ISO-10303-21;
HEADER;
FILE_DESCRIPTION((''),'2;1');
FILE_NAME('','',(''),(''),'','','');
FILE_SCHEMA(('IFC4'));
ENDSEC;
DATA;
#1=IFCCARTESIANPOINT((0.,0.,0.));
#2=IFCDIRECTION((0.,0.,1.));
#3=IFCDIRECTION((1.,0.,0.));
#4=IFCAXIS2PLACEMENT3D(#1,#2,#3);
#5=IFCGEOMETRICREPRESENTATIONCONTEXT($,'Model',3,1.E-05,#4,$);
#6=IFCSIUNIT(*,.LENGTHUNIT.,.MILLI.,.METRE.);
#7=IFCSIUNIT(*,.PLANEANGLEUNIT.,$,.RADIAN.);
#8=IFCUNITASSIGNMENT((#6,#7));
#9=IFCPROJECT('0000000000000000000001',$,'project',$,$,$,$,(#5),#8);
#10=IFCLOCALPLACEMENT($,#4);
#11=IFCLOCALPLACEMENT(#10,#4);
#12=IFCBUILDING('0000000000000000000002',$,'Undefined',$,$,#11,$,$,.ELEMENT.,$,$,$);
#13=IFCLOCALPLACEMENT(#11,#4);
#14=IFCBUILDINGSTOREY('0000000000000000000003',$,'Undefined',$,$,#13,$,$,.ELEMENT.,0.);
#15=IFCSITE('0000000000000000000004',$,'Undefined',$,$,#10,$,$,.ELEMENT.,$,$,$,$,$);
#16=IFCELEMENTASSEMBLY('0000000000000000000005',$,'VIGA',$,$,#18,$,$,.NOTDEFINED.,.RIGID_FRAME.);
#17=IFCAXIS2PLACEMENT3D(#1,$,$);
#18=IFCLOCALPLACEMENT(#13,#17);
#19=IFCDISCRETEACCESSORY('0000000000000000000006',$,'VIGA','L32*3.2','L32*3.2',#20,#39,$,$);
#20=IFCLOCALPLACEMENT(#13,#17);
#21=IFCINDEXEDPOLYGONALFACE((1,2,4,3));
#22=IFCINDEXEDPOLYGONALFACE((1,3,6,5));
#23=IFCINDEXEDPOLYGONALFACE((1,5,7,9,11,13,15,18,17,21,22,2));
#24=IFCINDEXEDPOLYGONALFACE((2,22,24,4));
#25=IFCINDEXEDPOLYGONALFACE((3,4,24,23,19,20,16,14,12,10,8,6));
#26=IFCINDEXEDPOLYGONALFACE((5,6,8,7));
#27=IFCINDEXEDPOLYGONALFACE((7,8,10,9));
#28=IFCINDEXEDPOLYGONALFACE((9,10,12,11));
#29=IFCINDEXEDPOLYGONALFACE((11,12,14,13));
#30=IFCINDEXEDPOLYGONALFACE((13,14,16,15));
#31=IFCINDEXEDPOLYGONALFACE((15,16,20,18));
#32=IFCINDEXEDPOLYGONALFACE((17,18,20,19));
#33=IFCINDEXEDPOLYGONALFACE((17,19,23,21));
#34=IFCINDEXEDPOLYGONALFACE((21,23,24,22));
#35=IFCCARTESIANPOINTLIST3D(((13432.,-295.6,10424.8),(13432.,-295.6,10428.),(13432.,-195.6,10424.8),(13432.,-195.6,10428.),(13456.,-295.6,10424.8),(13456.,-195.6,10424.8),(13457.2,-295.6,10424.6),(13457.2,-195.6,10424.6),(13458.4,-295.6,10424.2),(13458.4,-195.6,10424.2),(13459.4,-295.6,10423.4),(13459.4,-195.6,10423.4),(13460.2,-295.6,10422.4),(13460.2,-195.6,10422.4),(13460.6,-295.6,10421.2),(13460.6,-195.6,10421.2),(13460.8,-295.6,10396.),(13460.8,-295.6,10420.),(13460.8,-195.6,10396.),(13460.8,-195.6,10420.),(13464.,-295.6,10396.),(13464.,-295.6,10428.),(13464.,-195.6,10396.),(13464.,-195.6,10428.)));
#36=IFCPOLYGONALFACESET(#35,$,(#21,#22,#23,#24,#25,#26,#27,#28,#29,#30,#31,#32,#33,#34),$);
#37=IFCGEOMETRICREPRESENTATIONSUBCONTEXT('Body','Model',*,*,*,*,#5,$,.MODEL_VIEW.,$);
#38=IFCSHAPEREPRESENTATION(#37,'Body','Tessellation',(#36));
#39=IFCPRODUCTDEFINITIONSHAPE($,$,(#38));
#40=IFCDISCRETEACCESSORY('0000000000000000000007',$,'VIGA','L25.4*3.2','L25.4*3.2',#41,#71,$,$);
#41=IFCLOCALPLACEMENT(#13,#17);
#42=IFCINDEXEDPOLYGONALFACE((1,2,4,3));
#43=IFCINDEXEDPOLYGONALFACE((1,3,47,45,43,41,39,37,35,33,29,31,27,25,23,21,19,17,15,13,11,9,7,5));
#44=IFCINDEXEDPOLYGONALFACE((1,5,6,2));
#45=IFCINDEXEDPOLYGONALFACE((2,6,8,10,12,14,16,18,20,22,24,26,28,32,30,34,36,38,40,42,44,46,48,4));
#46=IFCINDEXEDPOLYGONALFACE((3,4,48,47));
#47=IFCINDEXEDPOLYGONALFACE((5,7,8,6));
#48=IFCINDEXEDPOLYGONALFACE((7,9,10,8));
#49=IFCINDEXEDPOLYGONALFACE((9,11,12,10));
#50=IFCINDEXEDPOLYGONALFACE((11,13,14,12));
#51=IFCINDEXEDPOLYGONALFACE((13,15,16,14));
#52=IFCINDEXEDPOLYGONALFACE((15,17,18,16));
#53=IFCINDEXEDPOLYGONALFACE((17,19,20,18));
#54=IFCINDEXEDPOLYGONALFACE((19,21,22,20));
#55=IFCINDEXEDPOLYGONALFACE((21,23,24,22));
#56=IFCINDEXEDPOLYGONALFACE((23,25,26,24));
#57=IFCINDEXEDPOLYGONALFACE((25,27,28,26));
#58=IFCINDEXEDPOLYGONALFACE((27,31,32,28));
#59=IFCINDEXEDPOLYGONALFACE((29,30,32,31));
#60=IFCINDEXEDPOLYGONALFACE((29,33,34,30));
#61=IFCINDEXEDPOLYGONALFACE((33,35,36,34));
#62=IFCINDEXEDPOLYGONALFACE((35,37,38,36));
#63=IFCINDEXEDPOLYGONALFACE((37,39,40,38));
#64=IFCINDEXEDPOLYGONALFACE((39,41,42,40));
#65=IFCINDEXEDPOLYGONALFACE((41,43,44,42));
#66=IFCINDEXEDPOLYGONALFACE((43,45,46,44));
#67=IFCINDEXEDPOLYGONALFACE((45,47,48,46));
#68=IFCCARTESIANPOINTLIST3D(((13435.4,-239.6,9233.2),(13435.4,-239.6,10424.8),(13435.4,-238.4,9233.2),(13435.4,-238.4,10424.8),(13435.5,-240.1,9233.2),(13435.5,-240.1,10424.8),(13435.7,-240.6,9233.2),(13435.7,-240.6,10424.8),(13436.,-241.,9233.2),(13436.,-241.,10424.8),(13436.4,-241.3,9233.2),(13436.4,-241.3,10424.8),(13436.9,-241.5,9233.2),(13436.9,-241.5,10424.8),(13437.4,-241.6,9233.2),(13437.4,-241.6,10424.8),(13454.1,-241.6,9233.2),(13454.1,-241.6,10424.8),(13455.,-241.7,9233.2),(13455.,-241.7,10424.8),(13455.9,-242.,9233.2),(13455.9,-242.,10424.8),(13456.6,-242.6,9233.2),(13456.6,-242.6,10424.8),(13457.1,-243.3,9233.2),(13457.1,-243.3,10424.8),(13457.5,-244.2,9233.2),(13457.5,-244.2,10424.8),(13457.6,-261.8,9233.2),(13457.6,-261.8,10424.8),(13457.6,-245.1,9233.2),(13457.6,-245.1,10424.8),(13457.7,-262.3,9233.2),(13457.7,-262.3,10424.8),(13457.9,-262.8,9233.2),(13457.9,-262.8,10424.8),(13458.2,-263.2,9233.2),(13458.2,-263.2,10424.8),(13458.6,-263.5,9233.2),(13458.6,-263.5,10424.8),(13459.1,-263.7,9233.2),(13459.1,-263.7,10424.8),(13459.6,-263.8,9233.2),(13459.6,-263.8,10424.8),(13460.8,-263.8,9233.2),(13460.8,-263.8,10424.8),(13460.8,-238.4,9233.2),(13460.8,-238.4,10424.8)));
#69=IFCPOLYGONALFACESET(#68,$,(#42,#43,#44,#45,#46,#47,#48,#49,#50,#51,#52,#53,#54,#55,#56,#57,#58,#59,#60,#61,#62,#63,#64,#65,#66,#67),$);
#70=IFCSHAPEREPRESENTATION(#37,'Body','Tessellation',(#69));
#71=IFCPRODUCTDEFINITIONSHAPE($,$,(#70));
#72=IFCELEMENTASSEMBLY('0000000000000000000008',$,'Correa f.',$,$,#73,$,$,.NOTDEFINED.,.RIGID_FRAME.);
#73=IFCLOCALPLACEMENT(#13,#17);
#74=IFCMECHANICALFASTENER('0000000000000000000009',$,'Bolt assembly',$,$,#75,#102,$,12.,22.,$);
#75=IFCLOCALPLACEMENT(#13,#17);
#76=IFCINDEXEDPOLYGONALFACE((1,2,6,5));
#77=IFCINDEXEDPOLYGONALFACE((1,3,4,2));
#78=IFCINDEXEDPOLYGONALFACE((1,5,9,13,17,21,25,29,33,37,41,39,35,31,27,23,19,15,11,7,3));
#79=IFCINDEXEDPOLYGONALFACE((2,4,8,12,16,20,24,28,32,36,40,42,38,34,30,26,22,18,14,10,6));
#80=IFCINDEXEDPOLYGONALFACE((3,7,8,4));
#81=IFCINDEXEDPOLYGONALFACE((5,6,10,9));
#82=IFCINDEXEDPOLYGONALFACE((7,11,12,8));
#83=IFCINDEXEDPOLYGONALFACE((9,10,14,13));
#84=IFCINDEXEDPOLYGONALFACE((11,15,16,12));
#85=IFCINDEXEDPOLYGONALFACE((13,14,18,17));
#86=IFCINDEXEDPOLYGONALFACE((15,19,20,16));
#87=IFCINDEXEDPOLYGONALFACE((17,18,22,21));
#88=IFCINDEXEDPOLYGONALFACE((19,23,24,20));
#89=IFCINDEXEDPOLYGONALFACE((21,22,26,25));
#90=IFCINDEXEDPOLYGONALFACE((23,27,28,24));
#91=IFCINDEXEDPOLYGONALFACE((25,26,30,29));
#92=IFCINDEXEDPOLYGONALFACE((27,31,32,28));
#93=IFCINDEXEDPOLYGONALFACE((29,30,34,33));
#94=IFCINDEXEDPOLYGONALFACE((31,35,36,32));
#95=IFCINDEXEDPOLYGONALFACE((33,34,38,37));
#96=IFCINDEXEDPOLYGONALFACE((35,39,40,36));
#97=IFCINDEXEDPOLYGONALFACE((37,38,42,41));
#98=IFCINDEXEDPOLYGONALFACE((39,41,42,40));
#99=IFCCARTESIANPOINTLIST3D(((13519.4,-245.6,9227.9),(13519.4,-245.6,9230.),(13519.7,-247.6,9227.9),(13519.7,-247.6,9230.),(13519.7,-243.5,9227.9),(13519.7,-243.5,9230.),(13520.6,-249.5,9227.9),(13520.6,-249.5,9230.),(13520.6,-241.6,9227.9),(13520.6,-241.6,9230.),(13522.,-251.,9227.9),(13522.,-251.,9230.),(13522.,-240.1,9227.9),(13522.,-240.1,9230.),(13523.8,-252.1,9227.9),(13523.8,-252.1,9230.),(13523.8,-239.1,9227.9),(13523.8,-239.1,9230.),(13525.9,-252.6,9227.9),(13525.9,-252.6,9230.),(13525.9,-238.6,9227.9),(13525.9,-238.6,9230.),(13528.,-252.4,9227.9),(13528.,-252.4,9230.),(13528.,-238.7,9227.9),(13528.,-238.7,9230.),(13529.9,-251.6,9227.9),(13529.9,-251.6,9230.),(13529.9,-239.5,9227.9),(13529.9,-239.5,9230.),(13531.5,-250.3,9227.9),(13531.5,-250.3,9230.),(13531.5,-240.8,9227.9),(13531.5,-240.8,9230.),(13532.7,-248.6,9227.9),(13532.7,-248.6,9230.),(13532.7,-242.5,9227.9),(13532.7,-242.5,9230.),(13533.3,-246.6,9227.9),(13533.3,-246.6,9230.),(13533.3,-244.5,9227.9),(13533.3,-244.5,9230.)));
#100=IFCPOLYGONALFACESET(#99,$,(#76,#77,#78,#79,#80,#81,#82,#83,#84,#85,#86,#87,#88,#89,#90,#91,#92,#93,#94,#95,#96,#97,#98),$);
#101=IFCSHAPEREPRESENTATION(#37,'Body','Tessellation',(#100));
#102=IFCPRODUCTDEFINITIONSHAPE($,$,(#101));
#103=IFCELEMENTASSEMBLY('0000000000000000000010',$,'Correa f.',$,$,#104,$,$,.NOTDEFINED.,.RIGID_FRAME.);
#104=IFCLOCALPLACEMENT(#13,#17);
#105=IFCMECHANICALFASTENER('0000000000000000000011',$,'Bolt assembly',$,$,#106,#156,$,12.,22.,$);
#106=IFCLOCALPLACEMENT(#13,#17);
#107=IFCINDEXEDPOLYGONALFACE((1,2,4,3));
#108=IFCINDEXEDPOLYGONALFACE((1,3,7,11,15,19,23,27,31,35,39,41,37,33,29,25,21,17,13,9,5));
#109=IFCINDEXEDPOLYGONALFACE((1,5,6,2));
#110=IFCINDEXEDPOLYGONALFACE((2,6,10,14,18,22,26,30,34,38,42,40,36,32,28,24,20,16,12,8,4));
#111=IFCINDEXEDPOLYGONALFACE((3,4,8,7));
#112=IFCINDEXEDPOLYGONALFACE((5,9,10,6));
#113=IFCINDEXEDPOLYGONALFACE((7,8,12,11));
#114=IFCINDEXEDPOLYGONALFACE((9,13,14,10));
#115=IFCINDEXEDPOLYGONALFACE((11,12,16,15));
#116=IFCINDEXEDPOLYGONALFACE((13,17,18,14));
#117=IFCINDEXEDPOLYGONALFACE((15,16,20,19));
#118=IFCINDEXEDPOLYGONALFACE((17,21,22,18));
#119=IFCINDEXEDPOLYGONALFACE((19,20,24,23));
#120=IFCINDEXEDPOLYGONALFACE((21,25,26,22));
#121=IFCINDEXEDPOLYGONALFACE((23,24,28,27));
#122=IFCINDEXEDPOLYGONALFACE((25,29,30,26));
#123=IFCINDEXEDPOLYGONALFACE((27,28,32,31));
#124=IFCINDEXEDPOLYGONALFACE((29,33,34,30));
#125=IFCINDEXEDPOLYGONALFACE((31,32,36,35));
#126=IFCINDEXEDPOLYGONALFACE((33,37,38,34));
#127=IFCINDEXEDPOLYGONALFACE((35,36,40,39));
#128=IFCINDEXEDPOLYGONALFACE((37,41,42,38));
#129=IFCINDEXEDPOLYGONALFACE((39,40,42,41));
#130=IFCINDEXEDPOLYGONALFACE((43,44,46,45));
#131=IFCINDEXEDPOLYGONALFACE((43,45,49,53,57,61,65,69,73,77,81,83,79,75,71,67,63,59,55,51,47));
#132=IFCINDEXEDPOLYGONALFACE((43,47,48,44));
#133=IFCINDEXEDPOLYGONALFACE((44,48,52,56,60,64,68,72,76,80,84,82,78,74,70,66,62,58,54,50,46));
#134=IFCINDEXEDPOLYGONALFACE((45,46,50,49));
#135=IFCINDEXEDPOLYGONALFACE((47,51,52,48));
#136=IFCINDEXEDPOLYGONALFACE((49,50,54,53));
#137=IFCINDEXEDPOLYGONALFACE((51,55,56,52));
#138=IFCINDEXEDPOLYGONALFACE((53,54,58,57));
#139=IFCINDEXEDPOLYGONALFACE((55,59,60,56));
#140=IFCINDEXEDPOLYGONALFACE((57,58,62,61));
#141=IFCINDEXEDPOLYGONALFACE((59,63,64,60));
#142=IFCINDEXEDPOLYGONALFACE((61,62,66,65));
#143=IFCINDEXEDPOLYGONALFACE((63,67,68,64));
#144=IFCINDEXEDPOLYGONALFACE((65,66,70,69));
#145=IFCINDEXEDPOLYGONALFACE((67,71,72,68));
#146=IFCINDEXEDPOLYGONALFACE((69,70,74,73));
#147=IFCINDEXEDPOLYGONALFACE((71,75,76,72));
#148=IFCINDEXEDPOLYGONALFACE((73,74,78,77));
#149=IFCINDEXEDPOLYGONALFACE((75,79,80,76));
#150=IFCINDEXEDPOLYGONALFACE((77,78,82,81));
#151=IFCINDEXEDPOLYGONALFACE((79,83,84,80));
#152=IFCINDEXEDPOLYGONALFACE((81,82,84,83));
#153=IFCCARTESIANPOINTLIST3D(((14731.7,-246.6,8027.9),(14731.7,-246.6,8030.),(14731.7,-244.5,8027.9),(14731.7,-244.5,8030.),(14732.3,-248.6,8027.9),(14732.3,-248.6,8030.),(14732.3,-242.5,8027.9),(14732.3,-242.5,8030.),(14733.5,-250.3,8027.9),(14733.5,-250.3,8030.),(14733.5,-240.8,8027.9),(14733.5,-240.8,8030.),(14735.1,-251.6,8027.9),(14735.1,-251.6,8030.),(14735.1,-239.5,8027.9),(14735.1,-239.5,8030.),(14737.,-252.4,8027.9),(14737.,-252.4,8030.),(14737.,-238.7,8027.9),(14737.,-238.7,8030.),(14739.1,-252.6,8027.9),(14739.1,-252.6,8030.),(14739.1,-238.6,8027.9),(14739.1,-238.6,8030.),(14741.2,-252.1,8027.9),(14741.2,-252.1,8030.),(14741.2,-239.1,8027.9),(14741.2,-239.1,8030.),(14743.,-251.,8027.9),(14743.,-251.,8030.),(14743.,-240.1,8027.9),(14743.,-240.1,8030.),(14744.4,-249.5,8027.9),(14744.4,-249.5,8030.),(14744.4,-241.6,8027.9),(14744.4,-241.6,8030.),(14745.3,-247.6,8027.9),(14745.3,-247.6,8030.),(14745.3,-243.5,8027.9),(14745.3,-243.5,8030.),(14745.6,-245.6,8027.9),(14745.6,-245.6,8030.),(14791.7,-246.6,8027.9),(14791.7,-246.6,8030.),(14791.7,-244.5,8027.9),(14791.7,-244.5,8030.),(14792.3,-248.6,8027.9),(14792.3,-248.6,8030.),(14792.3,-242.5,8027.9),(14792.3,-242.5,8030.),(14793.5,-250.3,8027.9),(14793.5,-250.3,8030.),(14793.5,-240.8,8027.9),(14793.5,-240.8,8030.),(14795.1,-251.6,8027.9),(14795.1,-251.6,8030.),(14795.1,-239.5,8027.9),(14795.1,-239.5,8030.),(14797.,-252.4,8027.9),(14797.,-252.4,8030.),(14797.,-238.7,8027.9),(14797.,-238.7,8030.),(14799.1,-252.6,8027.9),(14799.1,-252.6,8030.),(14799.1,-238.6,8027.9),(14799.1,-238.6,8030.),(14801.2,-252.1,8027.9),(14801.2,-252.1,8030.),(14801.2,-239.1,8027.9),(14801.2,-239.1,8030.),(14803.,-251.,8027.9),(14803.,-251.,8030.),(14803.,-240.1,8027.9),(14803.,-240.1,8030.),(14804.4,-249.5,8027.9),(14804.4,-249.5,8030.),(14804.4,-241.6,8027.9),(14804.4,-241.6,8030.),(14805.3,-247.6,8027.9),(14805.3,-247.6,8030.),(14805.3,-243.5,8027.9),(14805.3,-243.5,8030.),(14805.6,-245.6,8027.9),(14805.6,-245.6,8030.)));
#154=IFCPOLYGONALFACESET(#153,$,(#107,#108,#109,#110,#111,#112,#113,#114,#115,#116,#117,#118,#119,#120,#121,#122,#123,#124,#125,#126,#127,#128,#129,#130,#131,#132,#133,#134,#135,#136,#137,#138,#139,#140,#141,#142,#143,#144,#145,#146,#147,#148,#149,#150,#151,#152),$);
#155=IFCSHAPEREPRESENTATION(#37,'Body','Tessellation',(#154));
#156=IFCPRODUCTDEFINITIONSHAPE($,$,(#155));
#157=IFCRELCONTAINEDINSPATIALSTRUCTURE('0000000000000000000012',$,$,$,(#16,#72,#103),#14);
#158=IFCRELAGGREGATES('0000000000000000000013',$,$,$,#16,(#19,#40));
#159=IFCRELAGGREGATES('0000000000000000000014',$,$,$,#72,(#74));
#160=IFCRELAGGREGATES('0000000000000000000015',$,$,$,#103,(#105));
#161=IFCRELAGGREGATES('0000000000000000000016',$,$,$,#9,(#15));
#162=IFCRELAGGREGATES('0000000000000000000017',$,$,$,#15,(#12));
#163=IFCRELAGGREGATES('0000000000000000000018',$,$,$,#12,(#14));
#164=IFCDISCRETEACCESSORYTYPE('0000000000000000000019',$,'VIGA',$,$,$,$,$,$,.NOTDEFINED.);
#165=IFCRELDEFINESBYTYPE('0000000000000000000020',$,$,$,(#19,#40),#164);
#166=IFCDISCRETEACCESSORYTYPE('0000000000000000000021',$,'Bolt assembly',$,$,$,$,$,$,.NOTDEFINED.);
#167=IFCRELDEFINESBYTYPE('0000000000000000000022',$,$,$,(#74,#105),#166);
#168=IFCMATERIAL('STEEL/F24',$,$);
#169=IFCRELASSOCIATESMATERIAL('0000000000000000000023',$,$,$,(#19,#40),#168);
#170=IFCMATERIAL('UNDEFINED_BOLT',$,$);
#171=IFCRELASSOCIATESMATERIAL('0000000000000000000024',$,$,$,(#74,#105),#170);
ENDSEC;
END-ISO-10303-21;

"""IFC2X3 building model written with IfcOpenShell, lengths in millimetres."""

from ifc_helpers import new_model, si_unit, frame, origin_with_axes, origin_2d_with_axis, place, context, subcontext, project, spatial, circle, l_section, extrude, source, transform, mapped, material, type_object, element, aggregate, save


model = new_model("IFC2X3")

# Units and contexts
model_context = context("Model", 3, precision=1e-05, world=origin_with_axes())
body_context = subcontext(model_context, "Body", "Model", "MODEL_VIEW")
ifc_project = project(units=[si_unit("LENGTHUNIT", "METRE", prefix="MILLI"), si_unit("PLANEANGLEUNIT", "RADIAN")], contexts=[model_context])

# Site, building, storey
site_placement = place(None, origin_with_axes())
site = spatial("IfcSite", under=ifc_project, at=site_placement, Name="Undefined", CompositionType="ELEMENT")
building_placement = place(site_placement, origin_with_axes())
building = spatial("IfcBuilding", under=site, at=building_placement, Name="Undefined", CompositionType="ELEMENT")
storey_placement = place(building_placement, origin_with_axes())
storey = spatial("IfcBuildingStorey", under=building, at=storey_placement, Name="Undefined", CompositionType="ELEMENT", Elevation=0.0)

# Element assembly, discrete accessories
assembly_1_placement = place(storey_placement, origin_with_axes())
assembly_1 = element("IfcElementAssembly", 1, at=assembly_1_placement, inside=storey, Name="VIGA", AssemblyPlace="NOTDEFINED", PredefinedType="RIGID_FRAME")
ifc_material_1 = material(Name="STEEL/F24")
discrete_accessory_type_1 = type_object("IfcDiscreteAccessoryType", Name="VIGA")
discrete_accessory_1_placement = place(assembly_1_placement, frame((13448.0, -195.6, 10412.0), z_axis=(-1.0, 0.0, 0.0), x_axis=(0.0, -1.0, 0.0)))
discrete_accessory_1 = element("IfcDiscreteAccessory", 2, at=discrete_accessory_1_placement, type_object=discrete_accessory_type_1, material=ifc_material_1, Name="VIGA", Description="L32*3.2", ObjectType="L32*3.2", context=body_context, shape_type="SweptSolid", body=[
    extrude(l_section(Depth=32.0, Width=32.0, Thickness=3.2, FilletRadius=4.8, at=origin_2d_with_axis()), frame((100.0, 0.0, 0.0), z_axis=(-1.0, 0.0, 0.0), x_axis=(0.0, -1.0, 0.0)), (0.0, 0.0, 1.0), 100.0),
])
discrete_accessory_2_placement = place(assembly_1_placement, frame((13448.1, -251.1, 9233.2), z_axis=(-1.0, 0.0, 0.0), x_axis=(0.0, 0.0, 1.0)))
discrete_accessory_2 = element("IfcDiscreteAccessory", 3, at=discrete_accessory_2_placement, type_object=discrete_accessory_type_1, material=ifc_material_1, Name="VIGA", Description="L25.4*3.2", ObjectType="L25.4*3.2", context=body_context, shape_type="SweptSolid", body=[
    extrude(l_section(Depth=25.4, Width=25.4, Thickness=3.2, FilletRadius=3.5, EdgeRadius=2.0, at=origin_2d_with_axis()), frame((1191.6, 0.0, 0.0), z_axis=(-1.0, 0.0, 0.0), x_axis=(0.0, -1.0, 0.0)), (0.0, 0.0, 1.0), 1191.6),
])
aggregate(assembly_1, [discrete_accessory_1, discrete_accessory_2])

# Element assembly, mechanical fastener
assembly_2_placement = place(storey_placement, origin_with_axes())
assembly_2 = element("IfcElementAssembly", 4, at=assembly_2_placement, inside=storey, Name="Correa f.", AssemblyPlace="NOTDEFINED", PredefinedType="RIGID_FRAME")
ifc_material_2 = material(Name="UNDEFINED_BOLT")
discrete_accessory_type_2 = type_object("IfcDiscreteAccessoryType", Name="Bolt assembly")
shared_shape = source(origin_with_axes(), body_context, "Body", "SweptSolid", [
    extrude(circle(Radius=7.0, at=origin_2d_with_axis()), frame((0.0, -1.0, 0.0), z_axis=(0.0, 1.0, 0.0), x_axis=(1.0, 0.0, 0.0)), (0.0, 0.0, 1.0), 2.1),
])
mechanical_fastener_1_placement = place(assembly_2_placement, frame((13526.4, -245.6, 9229.0), z_axis=(0.0, -1.0, 0.0), x_axis=(-1.0, 0.0, 0.0)))
mechanical_fastener_1 = element("IfcMechanicalFastener", 5, at=mechanical_fastener_1_placement, type_object=discrete_accessory_type_2, material=ifc_material_2, Name="Bolt assembly", NominalDiameter=12.0, NominalLength=22.0, context=body_context, shape_type="MappedRepresentation", body=[
    mapped(shared_shape, transform((0.0, 0.0, 0.0))),
])
aggregate(assembly_2, [mechanical_fastener_1])

# Element assembly, mechanical fastener
assembly_3_placement = place(storey_placement, origin_with_axes())
assembly_3 = element("IfcElementAssembly", 6, at=assembly_3_placement, inside=storey, Name="Correa f.", AssemblyPlace="NOTDEFINED", PredefinedType="RIGID_FRAME")
mechanical_fastener_2_placement = place(assembly_3_placement, frame((14738.6, -245.6, 8029.0), z_axis=(0.0, 1.0, 0.0), x_axis=(1.0, 0.0, 0.0)))
mechanical_fastener_2 = element("IfcMechanicalFastener", 7, at=mechanical_fastener_2_placement, type_object=discrete_accessory_type_2, material=ifc_material_2, Name="Bolt assembly", NominalDiameter=12.0, NominalLength=22.0, context=body_context, shape_type="MappedRepresentation", body=[
    mapped(shared_shape, transform((0.0, 0.0, 0.0))),
    mapped(shared_shape, transform((60.0, 0.0, 0.0))),
])
aggregate(assembly_3, [mechanical_fastener_2])

save(model, "model.ifc")
